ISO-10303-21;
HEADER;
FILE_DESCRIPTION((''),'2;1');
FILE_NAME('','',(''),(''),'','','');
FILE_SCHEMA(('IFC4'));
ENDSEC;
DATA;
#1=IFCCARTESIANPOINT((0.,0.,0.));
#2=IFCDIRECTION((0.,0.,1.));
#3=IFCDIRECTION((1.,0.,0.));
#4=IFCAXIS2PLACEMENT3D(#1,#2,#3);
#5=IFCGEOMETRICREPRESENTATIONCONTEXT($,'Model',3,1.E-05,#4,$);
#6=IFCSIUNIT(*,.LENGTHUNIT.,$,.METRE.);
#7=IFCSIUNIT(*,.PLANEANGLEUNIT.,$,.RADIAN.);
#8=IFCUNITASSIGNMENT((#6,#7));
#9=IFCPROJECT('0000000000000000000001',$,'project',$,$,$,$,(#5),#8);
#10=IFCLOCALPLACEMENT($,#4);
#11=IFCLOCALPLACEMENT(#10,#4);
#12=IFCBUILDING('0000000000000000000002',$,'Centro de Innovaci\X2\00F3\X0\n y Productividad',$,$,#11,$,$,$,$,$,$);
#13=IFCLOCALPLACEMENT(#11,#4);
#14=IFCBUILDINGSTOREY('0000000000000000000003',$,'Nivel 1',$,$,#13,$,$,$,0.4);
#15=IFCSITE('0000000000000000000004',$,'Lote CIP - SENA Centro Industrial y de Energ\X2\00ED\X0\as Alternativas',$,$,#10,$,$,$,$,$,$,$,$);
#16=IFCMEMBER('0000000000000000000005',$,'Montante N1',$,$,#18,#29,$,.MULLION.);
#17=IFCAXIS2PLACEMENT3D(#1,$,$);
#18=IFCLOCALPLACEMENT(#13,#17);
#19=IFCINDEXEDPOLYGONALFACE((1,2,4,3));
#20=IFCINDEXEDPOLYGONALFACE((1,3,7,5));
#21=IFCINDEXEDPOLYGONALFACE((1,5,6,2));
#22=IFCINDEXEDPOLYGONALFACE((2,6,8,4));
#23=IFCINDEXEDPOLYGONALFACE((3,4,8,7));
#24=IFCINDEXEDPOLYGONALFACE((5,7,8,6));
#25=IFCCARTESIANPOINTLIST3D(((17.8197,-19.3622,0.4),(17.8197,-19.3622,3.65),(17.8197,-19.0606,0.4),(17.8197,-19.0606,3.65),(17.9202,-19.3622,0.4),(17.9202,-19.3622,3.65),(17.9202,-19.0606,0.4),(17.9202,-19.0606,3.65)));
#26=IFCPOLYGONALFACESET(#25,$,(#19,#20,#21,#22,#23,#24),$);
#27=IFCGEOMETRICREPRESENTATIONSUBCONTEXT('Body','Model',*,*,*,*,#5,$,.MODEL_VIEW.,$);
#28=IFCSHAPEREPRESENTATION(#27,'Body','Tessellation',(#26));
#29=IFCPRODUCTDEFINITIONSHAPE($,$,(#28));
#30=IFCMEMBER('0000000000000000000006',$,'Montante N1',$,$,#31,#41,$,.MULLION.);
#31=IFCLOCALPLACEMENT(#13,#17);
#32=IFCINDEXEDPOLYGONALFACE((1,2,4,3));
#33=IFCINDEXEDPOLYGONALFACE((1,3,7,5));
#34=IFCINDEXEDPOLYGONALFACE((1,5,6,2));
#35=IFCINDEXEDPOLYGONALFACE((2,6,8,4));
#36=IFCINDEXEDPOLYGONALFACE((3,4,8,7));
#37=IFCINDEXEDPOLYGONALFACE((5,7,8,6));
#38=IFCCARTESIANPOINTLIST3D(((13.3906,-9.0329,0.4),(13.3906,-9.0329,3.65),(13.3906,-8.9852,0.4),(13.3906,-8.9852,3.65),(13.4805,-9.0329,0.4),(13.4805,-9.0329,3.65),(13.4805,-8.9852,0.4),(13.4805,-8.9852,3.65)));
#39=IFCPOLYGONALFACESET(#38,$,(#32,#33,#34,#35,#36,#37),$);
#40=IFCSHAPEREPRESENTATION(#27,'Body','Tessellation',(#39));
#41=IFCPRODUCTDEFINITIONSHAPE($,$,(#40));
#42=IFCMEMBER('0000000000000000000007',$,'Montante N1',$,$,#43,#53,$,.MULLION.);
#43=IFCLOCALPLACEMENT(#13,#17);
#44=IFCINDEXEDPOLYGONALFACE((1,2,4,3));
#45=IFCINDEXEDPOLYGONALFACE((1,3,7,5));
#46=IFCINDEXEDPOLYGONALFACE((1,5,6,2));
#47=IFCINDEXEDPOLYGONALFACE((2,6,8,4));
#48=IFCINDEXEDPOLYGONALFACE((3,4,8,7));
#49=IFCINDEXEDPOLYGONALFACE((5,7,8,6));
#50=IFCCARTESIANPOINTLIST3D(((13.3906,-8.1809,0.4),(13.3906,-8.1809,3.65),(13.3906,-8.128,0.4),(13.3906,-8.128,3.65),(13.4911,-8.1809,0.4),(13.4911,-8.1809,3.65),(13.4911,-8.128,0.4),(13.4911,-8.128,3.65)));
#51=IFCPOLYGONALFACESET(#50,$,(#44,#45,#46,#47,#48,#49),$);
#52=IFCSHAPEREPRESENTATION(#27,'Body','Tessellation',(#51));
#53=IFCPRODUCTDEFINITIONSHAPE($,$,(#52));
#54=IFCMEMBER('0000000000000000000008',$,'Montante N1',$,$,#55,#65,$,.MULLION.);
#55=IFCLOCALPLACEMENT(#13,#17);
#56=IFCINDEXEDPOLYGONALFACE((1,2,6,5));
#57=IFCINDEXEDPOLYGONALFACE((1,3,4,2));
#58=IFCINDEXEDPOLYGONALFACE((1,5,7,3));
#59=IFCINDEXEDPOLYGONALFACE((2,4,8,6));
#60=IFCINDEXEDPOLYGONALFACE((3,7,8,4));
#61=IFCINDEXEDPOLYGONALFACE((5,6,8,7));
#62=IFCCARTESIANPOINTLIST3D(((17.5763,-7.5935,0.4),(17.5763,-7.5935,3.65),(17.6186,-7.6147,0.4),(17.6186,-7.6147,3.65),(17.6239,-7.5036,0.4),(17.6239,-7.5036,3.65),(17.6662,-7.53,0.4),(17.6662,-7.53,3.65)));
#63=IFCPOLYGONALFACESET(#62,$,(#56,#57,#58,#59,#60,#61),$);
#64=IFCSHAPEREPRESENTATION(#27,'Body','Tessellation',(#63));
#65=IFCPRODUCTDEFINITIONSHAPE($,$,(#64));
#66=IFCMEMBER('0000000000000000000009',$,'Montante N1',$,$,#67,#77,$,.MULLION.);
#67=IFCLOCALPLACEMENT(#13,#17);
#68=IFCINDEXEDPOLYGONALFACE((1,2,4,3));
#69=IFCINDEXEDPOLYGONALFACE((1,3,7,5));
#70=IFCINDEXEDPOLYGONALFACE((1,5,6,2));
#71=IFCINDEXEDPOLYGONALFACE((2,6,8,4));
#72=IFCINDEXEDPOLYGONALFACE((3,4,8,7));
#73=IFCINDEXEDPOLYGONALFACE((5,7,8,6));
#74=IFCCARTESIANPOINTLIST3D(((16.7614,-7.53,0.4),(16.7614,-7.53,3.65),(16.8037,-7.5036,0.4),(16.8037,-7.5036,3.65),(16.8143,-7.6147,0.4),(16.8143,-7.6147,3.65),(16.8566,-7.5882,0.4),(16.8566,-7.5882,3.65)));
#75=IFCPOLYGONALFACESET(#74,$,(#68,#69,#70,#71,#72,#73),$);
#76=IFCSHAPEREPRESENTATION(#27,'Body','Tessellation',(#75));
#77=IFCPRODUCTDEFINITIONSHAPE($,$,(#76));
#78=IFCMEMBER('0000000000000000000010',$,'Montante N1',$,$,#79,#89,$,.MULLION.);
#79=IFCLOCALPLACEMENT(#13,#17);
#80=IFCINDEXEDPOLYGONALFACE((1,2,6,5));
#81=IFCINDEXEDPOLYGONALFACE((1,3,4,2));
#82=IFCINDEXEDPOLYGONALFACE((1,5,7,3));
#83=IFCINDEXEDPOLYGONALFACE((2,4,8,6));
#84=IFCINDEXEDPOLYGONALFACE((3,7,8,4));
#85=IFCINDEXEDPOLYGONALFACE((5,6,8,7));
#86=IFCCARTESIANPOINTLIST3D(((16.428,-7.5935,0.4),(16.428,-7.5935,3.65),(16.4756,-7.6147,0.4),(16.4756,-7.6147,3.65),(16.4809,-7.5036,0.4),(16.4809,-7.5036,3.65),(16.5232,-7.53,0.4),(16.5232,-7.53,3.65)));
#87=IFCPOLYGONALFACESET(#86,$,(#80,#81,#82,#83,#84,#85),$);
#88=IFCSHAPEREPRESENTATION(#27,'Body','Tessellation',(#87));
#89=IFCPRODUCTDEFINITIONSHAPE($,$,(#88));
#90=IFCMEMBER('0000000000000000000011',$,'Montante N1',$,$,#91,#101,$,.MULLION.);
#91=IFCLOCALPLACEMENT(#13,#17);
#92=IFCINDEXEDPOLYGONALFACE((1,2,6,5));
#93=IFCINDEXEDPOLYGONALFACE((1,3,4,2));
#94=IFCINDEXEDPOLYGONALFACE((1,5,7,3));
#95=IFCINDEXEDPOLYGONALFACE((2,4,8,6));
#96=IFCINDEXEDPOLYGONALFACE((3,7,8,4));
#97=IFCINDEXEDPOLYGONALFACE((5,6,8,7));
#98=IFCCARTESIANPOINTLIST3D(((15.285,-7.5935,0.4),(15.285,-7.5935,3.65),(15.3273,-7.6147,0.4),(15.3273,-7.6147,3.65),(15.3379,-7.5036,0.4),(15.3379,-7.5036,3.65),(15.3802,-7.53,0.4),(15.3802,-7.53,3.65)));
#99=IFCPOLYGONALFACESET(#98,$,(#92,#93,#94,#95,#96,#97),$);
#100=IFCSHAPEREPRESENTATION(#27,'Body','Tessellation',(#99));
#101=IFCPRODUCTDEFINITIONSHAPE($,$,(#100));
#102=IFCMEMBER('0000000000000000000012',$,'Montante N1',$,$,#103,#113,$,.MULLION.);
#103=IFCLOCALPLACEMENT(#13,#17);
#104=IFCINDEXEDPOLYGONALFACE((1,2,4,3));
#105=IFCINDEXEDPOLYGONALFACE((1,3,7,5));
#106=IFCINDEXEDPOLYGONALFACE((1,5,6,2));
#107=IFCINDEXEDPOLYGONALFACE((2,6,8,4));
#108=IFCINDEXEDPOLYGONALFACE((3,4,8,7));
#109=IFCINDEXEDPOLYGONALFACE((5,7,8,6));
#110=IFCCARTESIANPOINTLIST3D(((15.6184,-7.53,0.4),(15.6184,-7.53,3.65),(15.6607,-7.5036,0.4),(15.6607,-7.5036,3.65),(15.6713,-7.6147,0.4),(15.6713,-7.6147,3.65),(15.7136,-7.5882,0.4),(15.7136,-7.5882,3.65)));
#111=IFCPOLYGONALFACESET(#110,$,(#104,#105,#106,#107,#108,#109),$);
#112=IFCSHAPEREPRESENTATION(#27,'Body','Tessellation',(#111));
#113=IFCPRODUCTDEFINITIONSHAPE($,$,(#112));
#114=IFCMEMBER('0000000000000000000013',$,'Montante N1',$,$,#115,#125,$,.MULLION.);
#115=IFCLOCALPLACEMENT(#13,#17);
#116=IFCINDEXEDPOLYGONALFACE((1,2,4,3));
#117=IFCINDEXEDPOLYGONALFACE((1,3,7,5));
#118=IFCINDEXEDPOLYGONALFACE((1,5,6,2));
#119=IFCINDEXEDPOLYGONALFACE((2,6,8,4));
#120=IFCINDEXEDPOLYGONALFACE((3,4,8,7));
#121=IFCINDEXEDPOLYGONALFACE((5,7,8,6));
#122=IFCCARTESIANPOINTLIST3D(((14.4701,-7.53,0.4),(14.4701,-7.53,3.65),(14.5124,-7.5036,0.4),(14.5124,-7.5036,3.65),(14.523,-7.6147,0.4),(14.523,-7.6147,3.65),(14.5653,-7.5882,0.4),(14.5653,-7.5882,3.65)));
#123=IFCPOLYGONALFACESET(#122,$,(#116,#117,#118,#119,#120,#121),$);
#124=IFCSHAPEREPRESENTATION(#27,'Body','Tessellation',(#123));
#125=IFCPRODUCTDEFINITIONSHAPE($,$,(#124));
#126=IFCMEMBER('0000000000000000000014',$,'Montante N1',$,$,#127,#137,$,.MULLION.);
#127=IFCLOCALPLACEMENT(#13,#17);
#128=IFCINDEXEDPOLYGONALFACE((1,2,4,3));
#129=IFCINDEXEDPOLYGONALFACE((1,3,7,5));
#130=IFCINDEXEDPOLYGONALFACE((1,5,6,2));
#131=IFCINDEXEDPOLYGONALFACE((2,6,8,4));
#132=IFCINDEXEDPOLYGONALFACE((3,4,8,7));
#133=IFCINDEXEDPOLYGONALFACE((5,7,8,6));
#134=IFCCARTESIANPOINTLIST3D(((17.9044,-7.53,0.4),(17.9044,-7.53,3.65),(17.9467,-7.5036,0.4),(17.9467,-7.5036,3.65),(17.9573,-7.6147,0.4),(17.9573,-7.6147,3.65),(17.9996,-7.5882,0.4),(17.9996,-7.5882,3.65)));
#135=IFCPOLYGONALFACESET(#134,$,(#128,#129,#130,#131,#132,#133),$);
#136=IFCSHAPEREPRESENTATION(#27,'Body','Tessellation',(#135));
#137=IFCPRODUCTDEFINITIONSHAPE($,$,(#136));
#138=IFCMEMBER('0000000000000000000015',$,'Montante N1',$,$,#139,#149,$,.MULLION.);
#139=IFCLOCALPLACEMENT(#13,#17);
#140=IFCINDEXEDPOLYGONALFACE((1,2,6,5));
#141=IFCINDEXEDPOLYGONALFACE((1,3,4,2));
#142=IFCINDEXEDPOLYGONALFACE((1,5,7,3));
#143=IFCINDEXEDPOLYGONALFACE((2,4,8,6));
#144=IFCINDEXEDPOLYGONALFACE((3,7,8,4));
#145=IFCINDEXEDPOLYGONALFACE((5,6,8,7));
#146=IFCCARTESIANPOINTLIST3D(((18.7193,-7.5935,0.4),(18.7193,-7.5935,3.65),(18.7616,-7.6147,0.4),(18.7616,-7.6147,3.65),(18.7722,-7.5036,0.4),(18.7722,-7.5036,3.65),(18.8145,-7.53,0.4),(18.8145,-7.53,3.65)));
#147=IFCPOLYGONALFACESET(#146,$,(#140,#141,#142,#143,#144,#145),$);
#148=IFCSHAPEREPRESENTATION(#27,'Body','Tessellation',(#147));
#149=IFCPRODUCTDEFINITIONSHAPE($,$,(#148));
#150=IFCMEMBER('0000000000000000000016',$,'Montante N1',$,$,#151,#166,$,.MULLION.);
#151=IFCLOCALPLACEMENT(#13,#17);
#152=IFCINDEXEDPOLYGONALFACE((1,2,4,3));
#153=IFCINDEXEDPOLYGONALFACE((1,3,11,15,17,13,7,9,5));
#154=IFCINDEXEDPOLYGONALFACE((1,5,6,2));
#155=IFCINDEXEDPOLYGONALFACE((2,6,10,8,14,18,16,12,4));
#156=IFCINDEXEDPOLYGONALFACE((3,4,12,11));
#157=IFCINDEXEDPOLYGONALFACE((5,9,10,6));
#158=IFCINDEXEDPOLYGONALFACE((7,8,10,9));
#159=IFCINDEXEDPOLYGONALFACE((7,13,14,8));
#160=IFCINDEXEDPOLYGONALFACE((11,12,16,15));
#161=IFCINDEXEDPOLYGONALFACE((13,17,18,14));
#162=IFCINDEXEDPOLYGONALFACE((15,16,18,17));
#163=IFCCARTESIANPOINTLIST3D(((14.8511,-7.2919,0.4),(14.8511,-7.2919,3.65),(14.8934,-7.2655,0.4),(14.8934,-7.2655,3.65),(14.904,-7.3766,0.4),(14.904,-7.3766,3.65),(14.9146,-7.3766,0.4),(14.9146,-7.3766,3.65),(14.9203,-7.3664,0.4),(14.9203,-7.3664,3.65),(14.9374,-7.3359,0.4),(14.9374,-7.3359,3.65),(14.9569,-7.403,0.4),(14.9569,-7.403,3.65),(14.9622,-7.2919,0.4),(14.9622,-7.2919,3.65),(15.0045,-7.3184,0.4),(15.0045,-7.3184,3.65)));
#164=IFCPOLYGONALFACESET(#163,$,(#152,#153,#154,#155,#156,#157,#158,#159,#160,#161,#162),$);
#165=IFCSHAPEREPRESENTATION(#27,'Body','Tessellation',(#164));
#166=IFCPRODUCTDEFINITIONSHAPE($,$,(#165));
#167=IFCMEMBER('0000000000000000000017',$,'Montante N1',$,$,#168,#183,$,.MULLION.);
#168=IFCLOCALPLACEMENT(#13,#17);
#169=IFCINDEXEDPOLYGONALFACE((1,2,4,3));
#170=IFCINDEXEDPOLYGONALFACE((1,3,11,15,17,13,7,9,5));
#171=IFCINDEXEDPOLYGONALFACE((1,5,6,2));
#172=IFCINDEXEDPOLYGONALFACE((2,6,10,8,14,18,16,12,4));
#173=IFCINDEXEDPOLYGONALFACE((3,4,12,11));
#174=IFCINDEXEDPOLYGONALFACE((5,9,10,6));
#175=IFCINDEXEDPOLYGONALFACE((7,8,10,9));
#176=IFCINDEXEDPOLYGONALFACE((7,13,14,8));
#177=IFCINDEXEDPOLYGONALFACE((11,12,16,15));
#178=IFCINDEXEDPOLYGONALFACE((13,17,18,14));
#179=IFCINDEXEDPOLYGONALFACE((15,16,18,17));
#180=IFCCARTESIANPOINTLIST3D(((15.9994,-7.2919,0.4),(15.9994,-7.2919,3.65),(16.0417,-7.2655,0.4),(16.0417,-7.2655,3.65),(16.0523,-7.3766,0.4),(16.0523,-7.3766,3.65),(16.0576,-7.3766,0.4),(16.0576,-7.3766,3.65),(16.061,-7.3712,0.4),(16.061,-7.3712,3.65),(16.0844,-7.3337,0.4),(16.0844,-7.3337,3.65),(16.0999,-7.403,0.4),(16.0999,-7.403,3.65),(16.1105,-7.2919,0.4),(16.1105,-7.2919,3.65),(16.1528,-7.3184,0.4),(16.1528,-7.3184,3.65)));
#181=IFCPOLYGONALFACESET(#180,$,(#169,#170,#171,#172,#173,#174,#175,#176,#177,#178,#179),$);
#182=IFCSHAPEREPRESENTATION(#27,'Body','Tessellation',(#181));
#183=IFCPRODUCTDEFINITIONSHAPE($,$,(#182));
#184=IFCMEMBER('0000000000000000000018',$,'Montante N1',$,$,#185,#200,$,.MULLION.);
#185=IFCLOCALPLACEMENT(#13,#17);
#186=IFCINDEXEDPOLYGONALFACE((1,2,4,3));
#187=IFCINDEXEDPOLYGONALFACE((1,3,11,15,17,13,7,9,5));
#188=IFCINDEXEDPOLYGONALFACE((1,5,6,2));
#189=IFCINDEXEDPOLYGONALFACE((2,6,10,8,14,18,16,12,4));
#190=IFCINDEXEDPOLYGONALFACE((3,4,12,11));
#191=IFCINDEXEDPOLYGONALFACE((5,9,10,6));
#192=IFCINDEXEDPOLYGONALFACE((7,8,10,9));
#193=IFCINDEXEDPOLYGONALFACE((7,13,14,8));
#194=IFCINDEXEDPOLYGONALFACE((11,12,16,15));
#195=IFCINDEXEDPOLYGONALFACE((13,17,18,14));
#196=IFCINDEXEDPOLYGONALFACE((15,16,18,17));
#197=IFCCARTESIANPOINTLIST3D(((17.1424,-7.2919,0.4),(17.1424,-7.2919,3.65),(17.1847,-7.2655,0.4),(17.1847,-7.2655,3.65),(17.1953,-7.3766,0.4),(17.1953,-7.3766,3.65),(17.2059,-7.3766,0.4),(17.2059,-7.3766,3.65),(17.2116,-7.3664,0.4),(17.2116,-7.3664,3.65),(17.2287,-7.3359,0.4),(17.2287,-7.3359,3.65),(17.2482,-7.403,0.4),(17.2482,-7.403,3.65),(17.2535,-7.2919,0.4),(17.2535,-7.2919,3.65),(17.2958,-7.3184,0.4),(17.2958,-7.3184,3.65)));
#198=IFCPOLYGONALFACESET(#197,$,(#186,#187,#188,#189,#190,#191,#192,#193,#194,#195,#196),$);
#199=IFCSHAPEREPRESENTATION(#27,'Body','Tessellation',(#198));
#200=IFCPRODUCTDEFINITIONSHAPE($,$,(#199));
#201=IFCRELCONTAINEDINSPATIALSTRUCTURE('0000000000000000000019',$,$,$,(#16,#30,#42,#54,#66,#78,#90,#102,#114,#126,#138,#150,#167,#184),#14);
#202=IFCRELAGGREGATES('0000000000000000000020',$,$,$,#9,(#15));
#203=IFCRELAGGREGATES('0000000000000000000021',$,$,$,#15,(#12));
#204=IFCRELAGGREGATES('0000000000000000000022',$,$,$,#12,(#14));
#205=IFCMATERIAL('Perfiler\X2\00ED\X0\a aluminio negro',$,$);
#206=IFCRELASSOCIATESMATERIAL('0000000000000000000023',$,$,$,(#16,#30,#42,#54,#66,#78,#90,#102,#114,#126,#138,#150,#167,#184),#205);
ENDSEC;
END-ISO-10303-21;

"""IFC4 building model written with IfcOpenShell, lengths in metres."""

from ifc_helpers import new_model, si_unit, frame, origin_with_axes, place, context, subcontext, project, spatial, polyline, outline, extrude, material, element, save


model = new_model("IFC4")

# Units and contexts
model_context = context("Model", 3, precision=1e-05, world=origin_with_axes())
body_context = subcontext(model_context, "Body", "Model", "MODEL_VIEW")
ifc_project = project(units=[si_unit("LENGTHUNIT", "METRE"), si_unit("PLANEANGLEUNIT", "RADIAN")], contexts=[model_context])

# Site, building, storey
site_placement = place(None, origin_with_axes())
site = spatial("IfcSite", under=ifc_project, at=site_placement, Name="Lote CIP - SENA Centro Industrial y de Energías Alternativas")
building_placement = place(site_placement, origin_with_axes())
building = spatial("IfcBuilding", under=site, at=building_placement, Name="Centro de Innovación y Productividad")
storey_placement = place(building_placement, origin_with_axes())
storey = spatial("IfcBuildingStorey", under=building, at=storey_placement, Name="Nivel 1", Elevation=0.4)

# Members
ifc_material = material(Name="Perfilería aluminio negro")
member_1_placement = place(storey_placement, origin_with_axes())
element("IfcMember", 1, at=member_1_placement, inside=storey, material=ifc_material, Name="Montante N1", PredefinedType="MULLION", context=body_context, shape_type="SweptSolid", body=[
    extrude(outline(polyline([(17.9202, -19.3622), (17.8197, -19.3622), (17.8197, -19.0606), (17.9202, -19.0606), (17.9202, -19.3622)])), frame((0.0, 0.0, 0.4)), (0.0, 0.0, 1.0), 3.25),
])
member_2_placement = place(storey_placement, origin_with_axes())
element("IfcMember", 2, at=member_2_placement, inside=storey, material=ifc_material, Name="Montante N1", PredefinedType="MULLION", context=body_context, shape_type="SweptSolid", body=[
    extrude(outline(polyline([(13.3906, -8.9853), (13.4805, -8.9853), (13.4805, -9.0329), (13.3906, -9.0329), (13.3906, -8.9853)])), frame((0.0, 0.0, 0.4)), (0.0, 0.0, 1.0), 3.25),
])
member_3_placement = place(storey_placement, origin_with_axes())
element("IfcMember", 3, at=member_3_placement, inside=storey, material=ifc_material, Name="Montante N1", PredefinedType="MULLION", context=body_context, shape_type="SweptSolid", body=[
    extrude(outline(polyline([(13.3906, -8.128), (13.4911, -8.128), (13.4911, -8.1809), (13.3906, -8.1809), (13.3906, -8.128)])), frame((0.0, 0.0, 0.4)), (0.0, 0.0, 1.0), 3.25),
])
member_4_placement = place(storey_placement, origin_with_axes())
element("IfcMember", 4, at=member_4_placement, inside=storey, material=ifc_material, Name="Montante N1", PredefinedType="MULLION", context=body_context, shape_type="SweptSolid", body=[
    extrude(outline(polyline([(17.6662, -7.53), (17.6186, -7.6147), (17.5763, -7.5935), (17.6239, -7.5036), (17.6662, -7.53)])), frame((0.0, 0.0, 0.4)), (0.0, 0.0, 1.0), 3.25),
])
member_5_placement = place(storey_placement, origin_with_axes())
element("IfcMember", 5, at=member_5_placement, inside=storey, material=ifc_material, Name="Montante N1", PredefinedType="MULLION", context=body_context, shape_type="SweptSolid", body=[
    extrude(outline(polyline([(16.8566, -7.5882), (16.8143, -7.6147), (16.7614, -7.53), (16.8037, -7.5036), (16.8566, -7.5882)])), frame((0.0, 0.0, 0.4)), (0.0, 0.0, 1.0), 3.25),
])
member_6_placement = place(storey_placement, origin_with_axes())
element("IfcMember", 6, at=member_6_placement, inside=storey, material=ifc_material, Name="Montante N1", PredefinedType="MULLION", context=body_context, shape_type="SweptSolid", body=[
    extrude(outline(polyline([(16.5232, -7.53), (16.4756, -7.6147), (16.428, -7.5935), (16.4809, -7.5036), (16.5232, -7.53)])), frame((0.0, 0.0, 0.4)), (0.0, 0.0, 1.0), 3.25),
])
member_7_placement = place(storey_placement, origin_with_axes())
element("IfcMember", 7, at=member_7_placement, inside=storey, material=ifc_material, Name="Montante N1", PredefinedType="MULLION", context=body_context, shape_type="SweptSolid", body=[
    extrude(outline(polyline([(15.3802, -7.53), (15.3273, -7.6147), (15.285, -7.5935), (15.3379, -7.5036), (15.3802, -7.53)])), frame((0.0, 0.0, 0.4)), (0.0, 0.0, 1.0), 3.25),
])
member_8_placement = place(storey_placement, origin_with_axes())
element("IfcMember", 8, at=member_8_placement, inside=storey, material=ifc_material, Name="Montante N1", PredefinedType="MULLION", context=body_context, shape_type="SweptSolid", body=[
    extrude(outline(polyline([(15.6184, -7.53), (15.6607, -7.5036), (15.7136, -7.5882), (15.6713, -7.6147), (15.6184, -7.53)])), frame((0.0, 0.0, 0.4)), (0.0, 0.0, 1.0), 3.25),
])
member_9_placement = place(storey_placement, origin_with_axes())
element("IfcMember", 9, at=member_9_placement, inside=storey, material=ifc_material, Name="Montante N1", PredefinedType="MULLION", context=body_context, shape_type="SweptSolid", body=[
    extrude(outline(polyline([(14.4701, -7.53), (14.5124, -7.5036), (14.5653, -7.5882), (14.523, -7.6147), (14.4701, -7.53)])), frame((0.0, 0.0, 0.4)), (0.0, 0.0, 1.0), 3.25),
])
member_10_placement = place(storey_placement, origin_with_axes())
element("IfcMember", 10, at=member_10_placement, inside=storey, material=ifc_material, Name="Montante N1", PredefinedType="MULLION", context=body_context, shape_type="SweptSolid", body=[
    extrude(outline(polyline([(17.9044, -7.53), (17.9467, -7.5036), (17.9996, -7.5882), (17.9573, -7.6147), (17.9044, -7.53)])), frame((0.0, 0.0, 0.4)), (0.0, 0.0, 1.0), 3.25),
])
member_11_placement = place(storey_placement, origin_with_axes())
element("IfcMember", 11, at=member_11_placement, inside=storey, material=ifc_material, Name="Montante N1", PredefinedType="MULLION", context=body_context, shape_type="SweptSolid", body=[
    extrude(outline(polyline([(18.8145, -7.53), (18.7616, -7.6147), (18.7193, -7.5935), (18.7722, -7.5036), (18.8145, -7.53)])), frame((0.0, 0.0, 0.4)), (0.0, 0.0, 1.0), 3.25),
])
member_12_placement = place(storey_placement, origin_with_axes())
element("IfcMember", 12, at=member_12_placement, inside=storey, material=ifc_material, Name="Montante N1", PredefinedType="MULLION", context=body_context, shape_type="SweptSolid", body=[
    extrude(outline(polyline([(14.9569, -7.403), (14.9146, -7.3766), (14.9203, -7.3664), (14.904, -7.3766), (14.8511, -7.2919), (14.8934, -7.2655), (14.9374, -7.3359), (14.9622, -7.2919), (15.0045, -7.3184), (14.9569, -7.403)])), frame((0.0, 0.0, 0.4)), (0.0, 0.0, 1.0), 3.25),
])
member_13_placement = place(storey_placement, origin_with_axes())
element("IfcMember", 13, at=member_13_placement, inside=storey, material=ifc_material, Name="Montante N1", PredefinedType="MULLION", context=body_context, shape_type="SweptSolid", body=[
    extrude(outline(polyline([(16.1105, -7.2919), (16.1528, -7.3184), (16.0999, -7.403), (16.0576, -7.3766), (16.061, -7.3712), (16.0523, -7.3766), (15.9994, -7.2919), (16.0417, -7.2655), (16.0844, -7.3337), (16.1105, -7.2919)])), frame((0.0, 0.0, 0.4)), (0.0, 0.0, 1.0), 3.25),
])
member_14_placement = place(storey_placement, origin_with_axes())
element("IfcMember", 14, at=member_14_placement, inside=storey, material=ifc_material, Name="Montante N1", PredefinedType="MULLION", context=body_context, shape_type="SweptSolid", body=[
    extrude(outline(polyline([(17.1847, -7.2655), (17.2287, -7.3359), (17.2535, -7.2919), (17.2958, -7.3184), (17.2482, -7.403), (17.2059, -7.3766), (17.2116, -7.3664), (17.1953, -7.3766), (17.1424, -7.2919), (17.1847, -7.2655)])), frame((0.0, 0.0, 0.4)), (0.0, 0.0, 1.0), 3.25),
])

save(model, "model.ifc")
